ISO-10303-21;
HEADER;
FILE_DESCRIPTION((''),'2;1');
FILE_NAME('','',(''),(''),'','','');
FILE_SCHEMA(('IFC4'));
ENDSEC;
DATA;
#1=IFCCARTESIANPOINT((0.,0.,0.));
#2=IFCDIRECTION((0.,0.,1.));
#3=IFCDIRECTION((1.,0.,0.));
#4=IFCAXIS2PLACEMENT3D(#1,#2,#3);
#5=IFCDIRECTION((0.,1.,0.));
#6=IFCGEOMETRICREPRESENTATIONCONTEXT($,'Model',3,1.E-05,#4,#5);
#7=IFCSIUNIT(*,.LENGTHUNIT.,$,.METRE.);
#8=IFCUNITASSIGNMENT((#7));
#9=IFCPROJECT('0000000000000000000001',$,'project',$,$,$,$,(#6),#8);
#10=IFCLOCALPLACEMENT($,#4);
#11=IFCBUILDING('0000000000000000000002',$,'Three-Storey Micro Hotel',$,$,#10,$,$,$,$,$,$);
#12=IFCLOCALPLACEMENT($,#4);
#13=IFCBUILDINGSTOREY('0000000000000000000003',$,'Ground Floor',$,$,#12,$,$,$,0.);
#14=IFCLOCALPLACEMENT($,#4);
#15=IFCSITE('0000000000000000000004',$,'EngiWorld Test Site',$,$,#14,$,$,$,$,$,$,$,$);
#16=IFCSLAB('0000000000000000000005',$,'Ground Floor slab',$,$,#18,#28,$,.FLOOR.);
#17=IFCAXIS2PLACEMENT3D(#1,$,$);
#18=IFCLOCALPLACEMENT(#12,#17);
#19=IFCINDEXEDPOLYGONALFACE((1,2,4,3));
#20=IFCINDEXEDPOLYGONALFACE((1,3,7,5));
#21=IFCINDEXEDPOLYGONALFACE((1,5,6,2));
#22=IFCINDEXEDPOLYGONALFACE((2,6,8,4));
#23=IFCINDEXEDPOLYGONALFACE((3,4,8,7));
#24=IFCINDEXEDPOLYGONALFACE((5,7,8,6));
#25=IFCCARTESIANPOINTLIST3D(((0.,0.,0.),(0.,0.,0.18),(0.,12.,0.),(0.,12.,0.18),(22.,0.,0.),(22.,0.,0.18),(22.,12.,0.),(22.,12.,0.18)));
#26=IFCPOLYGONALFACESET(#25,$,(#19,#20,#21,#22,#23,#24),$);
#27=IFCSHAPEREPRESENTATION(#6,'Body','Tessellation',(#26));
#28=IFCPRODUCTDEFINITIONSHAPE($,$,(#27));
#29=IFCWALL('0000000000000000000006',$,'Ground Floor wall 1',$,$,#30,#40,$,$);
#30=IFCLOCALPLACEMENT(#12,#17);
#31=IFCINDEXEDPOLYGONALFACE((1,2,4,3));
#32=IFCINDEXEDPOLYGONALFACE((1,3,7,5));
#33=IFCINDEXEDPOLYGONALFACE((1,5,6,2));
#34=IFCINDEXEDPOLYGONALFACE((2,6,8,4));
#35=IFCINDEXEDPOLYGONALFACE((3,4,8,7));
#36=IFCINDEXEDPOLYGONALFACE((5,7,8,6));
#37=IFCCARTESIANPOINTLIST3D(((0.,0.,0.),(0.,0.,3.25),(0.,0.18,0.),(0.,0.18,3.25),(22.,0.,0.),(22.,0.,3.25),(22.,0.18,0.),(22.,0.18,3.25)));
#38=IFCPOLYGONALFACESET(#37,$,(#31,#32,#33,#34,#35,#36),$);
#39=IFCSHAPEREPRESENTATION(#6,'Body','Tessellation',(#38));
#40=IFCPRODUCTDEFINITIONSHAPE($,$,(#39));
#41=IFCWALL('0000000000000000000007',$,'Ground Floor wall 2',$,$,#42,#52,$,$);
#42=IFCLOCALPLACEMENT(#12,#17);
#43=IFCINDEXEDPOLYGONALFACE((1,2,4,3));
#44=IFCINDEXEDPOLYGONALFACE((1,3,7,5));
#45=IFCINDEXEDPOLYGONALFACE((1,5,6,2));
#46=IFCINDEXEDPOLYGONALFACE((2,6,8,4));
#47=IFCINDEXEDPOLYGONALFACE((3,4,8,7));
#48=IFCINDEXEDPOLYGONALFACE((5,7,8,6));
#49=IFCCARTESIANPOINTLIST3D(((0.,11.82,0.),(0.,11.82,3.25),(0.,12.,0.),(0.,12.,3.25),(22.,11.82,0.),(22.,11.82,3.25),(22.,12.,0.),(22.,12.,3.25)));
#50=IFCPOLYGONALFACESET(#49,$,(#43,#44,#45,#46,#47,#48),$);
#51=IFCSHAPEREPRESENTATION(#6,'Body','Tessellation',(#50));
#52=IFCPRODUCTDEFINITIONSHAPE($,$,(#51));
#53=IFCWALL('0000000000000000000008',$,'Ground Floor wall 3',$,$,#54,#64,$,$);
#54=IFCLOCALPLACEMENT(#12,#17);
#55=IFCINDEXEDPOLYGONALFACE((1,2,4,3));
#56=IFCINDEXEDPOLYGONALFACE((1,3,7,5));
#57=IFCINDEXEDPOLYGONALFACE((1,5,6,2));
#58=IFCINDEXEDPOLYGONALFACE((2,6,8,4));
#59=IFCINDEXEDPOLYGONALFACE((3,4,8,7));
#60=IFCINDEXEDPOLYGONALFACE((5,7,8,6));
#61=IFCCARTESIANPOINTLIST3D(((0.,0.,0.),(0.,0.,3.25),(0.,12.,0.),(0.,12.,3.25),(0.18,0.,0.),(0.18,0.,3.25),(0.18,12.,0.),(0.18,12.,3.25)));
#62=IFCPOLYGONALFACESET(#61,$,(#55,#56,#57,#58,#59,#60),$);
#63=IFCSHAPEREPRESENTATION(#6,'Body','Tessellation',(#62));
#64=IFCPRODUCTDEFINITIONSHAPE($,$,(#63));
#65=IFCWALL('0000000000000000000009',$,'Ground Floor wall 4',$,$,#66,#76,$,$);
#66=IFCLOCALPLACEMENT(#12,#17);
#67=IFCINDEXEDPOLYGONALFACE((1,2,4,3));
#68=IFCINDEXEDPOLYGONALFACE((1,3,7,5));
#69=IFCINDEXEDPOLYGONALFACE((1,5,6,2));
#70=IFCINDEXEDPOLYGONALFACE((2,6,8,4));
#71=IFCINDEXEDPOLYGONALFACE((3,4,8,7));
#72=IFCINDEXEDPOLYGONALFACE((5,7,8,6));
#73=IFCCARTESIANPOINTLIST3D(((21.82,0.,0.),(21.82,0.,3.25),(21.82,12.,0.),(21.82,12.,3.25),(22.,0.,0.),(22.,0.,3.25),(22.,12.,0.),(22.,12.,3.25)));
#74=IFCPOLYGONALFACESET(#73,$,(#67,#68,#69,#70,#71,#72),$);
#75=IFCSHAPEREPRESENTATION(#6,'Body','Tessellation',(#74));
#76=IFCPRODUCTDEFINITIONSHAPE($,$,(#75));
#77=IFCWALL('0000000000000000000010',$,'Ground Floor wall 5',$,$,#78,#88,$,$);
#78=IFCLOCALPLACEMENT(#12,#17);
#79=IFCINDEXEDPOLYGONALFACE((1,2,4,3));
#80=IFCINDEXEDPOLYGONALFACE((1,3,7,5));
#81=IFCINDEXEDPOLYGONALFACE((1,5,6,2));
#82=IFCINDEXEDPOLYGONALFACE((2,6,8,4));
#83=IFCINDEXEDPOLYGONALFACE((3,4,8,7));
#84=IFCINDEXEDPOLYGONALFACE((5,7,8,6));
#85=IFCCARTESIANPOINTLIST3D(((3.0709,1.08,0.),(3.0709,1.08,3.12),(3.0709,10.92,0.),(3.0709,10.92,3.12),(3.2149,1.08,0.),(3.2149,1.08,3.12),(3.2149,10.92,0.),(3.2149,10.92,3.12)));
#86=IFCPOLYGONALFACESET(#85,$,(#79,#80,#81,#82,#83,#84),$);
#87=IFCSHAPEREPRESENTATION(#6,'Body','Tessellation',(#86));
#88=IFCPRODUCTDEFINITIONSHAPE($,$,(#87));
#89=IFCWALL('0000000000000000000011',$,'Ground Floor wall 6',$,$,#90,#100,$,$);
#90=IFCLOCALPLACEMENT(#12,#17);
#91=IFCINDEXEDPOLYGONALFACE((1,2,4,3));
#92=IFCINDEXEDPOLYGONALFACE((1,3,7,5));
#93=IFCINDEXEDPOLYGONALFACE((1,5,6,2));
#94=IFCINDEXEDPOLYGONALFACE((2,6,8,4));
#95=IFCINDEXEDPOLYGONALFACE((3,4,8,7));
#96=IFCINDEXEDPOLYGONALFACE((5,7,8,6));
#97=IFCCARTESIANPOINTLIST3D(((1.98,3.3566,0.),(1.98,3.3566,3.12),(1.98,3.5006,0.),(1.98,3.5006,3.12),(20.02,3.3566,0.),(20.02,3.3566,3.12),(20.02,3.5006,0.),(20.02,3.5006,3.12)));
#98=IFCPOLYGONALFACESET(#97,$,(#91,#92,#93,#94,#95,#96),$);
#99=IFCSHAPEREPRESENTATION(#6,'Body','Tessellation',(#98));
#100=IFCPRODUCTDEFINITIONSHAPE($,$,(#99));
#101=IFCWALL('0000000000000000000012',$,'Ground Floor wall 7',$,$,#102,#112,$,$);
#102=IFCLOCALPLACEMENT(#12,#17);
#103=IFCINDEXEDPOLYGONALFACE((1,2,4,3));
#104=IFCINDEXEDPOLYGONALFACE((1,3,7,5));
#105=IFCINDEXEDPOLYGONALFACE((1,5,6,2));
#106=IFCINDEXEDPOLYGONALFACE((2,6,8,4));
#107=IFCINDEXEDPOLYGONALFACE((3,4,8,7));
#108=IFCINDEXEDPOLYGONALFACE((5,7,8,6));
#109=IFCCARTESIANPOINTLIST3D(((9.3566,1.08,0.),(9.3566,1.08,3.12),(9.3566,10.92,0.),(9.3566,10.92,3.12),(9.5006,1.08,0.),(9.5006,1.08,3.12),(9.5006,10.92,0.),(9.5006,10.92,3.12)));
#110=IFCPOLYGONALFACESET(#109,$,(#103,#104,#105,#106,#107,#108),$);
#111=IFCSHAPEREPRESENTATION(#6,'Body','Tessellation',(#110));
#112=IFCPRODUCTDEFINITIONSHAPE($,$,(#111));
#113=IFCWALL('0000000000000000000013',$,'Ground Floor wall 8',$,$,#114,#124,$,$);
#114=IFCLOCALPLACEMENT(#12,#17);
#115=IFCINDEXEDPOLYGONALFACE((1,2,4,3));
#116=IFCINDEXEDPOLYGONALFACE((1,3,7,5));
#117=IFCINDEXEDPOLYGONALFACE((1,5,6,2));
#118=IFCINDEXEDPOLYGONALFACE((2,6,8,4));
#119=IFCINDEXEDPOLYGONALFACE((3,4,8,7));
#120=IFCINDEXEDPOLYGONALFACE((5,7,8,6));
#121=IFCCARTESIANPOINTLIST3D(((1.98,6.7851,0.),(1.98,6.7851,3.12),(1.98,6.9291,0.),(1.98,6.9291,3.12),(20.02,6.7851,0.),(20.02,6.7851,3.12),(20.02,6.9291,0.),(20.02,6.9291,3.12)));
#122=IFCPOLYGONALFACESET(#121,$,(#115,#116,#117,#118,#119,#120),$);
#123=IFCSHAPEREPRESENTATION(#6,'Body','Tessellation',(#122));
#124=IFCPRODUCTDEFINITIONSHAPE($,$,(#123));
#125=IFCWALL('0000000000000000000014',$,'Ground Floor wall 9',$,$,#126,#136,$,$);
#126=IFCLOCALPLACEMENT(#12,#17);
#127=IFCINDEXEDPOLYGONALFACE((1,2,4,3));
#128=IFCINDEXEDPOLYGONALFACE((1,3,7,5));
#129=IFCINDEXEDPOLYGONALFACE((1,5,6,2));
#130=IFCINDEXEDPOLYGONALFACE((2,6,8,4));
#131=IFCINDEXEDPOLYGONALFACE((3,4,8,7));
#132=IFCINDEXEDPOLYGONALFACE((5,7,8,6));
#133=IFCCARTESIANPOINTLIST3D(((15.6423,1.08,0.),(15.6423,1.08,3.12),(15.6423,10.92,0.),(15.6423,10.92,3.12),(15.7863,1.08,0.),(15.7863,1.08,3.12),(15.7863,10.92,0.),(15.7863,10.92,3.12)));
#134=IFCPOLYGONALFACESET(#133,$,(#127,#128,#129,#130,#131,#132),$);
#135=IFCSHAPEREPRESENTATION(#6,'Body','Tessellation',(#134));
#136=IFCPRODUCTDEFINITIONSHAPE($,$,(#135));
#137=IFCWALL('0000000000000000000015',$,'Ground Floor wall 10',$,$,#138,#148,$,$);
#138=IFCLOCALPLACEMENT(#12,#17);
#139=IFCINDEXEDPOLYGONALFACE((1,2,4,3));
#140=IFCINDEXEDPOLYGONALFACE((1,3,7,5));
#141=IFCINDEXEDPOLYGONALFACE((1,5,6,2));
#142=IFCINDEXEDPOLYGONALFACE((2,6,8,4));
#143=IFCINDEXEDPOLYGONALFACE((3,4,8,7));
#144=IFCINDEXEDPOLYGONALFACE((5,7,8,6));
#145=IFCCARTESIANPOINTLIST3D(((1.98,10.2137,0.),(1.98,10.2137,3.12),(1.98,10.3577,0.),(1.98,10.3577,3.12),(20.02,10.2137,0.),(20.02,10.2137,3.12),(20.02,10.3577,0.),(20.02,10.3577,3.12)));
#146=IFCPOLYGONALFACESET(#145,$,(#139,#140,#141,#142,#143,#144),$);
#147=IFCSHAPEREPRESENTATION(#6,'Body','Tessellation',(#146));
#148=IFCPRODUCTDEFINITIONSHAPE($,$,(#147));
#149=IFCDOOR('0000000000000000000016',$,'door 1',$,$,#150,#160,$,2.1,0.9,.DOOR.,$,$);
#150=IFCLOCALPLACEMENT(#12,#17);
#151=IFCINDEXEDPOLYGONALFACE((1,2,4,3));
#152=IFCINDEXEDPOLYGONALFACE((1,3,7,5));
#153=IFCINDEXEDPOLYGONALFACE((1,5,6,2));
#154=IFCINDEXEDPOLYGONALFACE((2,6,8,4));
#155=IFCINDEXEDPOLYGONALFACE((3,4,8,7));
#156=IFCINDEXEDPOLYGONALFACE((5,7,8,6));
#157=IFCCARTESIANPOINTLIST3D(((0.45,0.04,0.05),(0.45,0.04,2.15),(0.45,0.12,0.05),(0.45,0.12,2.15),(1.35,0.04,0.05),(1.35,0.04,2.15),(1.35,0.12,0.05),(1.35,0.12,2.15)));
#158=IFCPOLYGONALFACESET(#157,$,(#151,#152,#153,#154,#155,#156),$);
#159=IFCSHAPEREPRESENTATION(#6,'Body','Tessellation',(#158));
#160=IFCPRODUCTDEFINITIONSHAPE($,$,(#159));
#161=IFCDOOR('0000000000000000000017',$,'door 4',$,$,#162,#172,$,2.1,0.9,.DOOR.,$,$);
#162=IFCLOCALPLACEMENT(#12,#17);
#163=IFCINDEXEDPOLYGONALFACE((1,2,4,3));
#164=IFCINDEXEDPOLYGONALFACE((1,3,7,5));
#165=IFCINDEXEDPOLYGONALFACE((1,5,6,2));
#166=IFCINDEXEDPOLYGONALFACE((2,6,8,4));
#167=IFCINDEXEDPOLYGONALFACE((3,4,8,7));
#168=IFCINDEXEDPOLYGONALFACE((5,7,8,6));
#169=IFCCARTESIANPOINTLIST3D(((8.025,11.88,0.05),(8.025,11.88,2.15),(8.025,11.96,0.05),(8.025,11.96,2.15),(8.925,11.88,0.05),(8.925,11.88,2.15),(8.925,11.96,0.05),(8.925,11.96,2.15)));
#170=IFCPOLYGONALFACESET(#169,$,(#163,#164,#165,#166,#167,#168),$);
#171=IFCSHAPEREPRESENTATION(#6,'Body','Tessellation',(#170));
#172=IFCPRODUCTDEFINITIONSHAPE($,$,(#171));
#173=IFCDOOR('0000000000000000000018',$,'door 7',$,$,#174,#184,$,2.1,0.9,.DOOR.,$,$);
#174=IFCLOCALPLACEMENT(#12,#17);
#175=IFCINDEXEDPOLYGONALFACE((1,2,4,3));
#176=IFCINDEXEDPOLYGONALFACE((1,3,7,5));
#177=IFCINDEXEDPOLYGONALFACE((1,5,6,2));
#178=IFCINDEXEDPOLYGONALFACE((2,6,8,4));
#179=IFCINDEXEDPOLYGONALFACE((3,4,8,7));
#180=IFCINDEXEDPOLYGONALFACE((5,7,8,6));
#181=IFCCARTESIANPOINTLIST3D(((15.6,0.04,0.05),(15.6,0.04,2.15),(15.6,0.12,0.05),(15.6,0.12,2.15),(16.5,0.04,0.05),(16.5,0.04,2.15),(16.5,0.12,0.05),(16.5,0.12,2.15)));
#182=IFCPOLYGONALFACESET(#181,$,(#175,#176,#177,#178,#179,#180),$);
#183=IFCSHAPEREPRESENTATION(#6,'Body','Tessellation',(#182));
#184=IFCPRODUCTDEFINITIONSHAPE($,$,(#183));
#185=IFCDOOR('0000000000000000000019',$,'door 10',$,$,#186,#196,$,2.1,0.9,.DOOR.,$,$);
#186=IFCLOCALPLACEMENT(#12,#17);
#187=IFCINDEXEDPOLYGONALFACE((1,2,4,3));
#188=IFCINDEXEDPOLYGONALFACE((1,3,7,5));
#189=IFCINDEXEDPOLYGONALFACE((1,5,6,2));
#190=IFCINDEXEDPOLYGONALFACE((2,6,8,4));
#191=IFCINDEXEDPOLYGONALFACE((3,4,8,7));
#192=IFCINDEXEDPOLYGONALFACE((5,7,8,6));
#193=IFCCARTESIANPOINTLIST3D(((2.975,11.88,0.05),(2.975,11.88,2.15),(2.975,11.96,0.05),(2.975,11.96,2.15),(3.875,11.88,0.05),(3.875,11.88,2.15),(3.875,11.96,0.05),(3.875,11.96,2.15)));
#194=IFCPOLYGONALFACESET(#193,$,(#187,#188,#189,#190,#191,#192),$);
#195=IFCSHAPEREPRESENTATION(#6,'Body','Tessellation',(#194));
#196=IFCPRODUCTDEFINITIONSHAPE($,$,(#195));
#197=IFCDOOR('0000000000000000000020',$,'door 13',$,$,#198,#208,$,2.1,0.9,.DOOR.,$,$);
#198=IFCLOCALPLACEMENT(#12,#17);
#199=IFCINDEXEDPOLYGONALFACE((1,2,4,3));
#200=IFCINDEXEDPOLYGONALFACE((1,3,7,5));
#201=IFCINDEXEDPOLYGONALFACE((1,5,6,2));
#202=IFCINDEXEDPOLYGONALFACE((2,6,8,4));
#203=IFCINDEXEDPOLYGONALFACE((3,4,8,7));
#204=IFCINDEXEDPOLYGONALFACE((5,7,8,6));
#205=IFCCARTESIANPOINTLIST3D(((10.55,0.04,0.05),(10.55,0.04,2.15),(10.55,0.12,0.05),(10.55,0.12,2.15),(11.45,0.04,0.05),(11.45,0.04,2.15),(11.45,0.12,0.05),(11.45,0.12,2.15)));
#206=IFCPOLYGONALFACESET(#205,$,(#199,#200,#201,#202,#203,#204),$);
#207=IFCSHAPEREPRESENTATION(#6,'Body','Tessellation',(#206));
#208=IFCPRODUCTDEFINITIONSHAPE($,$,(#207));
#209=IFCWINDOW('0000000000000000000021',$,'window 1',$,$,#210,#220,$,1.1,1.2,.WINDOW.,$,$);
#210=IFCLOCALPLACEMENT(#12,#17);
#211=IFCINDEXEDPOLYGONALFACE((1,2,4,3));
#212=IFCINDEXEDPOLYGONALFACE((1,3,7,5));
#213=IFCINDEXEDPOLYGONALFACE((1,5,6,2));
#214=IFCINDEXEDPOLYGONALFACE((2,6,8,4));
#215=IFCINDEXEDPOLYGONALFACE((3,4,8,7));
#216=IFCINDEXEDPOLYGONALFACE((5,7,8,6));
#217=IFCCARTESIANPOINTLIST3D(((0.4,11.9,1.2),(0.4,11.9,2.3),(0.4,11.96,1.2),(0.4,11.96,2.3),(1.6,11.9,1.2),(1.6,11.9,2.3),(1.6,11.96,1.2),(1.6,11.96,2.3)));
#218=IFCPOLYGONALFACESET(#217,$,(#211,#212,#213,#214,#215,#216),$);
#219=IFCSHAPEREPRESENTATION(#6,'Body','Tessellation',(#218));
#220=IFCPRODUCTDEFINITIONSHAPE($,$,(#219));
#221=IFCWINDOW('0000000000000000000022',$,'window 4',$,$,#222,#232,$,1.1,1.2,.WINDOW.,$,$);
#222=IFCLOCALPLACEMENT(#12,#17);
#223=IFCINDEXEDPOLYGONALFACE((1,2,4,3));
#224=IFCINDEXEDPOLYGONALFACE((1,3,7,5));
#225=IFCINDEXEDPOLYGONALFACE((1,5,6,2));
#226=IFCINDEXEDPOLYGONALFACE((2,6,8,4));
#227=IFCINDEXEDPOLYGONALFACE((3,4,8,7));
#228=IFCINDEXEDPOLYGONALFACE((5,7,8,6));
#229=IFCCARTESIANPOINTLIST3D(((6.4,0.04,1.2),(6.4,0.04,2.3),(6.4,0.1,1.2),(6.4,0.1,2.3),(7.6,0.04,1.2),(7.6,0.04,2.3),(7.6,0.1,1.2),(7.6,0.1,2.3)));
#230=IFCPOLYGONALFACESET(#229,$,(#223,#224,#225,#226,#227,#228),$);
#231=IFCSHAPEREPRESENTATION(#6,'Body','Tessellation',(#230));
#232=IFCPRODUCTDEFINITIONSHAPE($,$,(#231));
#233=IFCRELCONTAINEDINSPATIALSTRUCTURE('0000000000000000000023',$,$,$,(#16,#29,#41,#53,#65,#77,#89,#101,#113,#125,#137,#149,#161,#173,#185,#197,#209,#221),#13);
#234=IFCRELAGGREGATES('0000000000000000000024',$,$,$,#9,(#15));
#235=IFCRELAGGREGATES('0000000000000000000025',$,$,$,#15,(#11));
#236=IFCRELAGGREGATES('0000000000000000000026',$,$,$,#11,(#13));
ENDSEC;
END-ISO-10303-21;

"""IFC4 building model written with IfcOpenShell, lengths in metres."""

from ifc_helpers import new_model, si_unit, direction, frame, origin_with_axes, origin_2d_with_axis, place, context, project, spatial, rectangle, extrude, element, save


model = new_model("IFC4")

# Units and contexts
model_context = context("Model", 3, precision=1e-05, world=origin_with_axes(), true_north=direction((0.0, 1.0, 0.0)))
ifc_project = project(units=[si_unit("LENGTHUNIT", "METRE")], contexts=[model_context])

# Site, building, storey
site_placement = place(None, origin_with_axes())
site = spatial("IfcSite", under=ifc_project, at=site_placement, Name="EngiWorld Test Site")
building_placement = place(None, origin_with_axes())
building = spatial("IfcBuilding", under=site, at=building_placement, Name="Three-Storey Micro Hotel")
storey_placement = place(None, origin_with_axes())
storey = spatial("IfcBuildingStorey", under=building, at=storey_placement, Name="Ground Floor", Elevation=0.0)

# Slab
slab_placement = place(None, frame((11.0, 6.0, 0.0), z_axis=(0.0, 0.0, 1.0), x_axis=(1.0, 0.0, 0.0)))
element("IfcSlab", 1, at=slab_placement, inside=storey, Name="Ground Floor slab", PredefinedType="FLOOR", context=model_context, shape_type="SweptSolid", body=[
    extrude(rectangle(XDim=22.0, YDim=12.0, at=origin_2d_with_axis()), origin_with_axes(), (0.0, 0.0, 1.0), 0.18),
])

# Walls
for number, where, z_axis, x_axis, name in (
    (2, (11.0, 0.09, 0.0), (0.0, 0.0, 1.0), (1.0, 0.0, 0.0), "Ground Floor wall 1"),
    (3, (11.0, 11.91, 0.0), (0.0, 0.0, 1.0), (1.0, 0.0, 0.0), "Ground Floor wall 2"),
):
    element("IfcWall", number, at=place(None, frame(where, z_axis=z_axis, x_axis=x_axis)), inside=storey, Name=name, context=model_context, shape_type="SweptSolid", body=[
        extrude(rectangle(XDim=22.0, YDim=0.18, at=origin_2d_with_axis()), origin_with_axes(), (0.0, 0.0, 1.0), 3.25),
    ])
for number, where, z_axis, x_axis, name in (
    (4, (0.09, 6.0, 0.0), (0.0, 0.0, 1.0), (1.0, 0.0, 0.0), "Ground Floor wall 3"),
    (5, (21.91, 6.0, 0.0), (0.0, 0.0, 1.0), (1.0, 0.0, 0.0), "Ground Floor wall 4"),
):
    element("IfcWall", number, at=place(None, frame(where, z_axis=z_axis, x_axis=x_axis)), inside=storey, Name=name, context=model_context, shape_type="SweptSolid", body=[
        extrude(rectangle(XDim=0.18, YDim=12.0, at=origin_2d_with_axis()), origin_with_axes(), (0.0, 0.0, 1.0), 3.25),
    ])
wall_1_placement = place(None, frame((3.1429, 6.0, 0.0), z_axis=(0.0, 0.0, 1.0), x_axis=(1.0, 0.0, 0.0)))
element("IfcWall", 6, at=wall_1_placement, inside=storey, Name="Ground Floor wall 5", context=model_context, shape_type="SweptSolid", body=[
    extrude(rectangle(XDim=0.144, YDim=9.84, at=origin_2d_with_axis()), origin_with_axes(), (0.0, 0.0, 1.0), 3.12),
])
wall_2_placement = place(None, frame((11.0, 3.4286, 0.0), z_axis=(0.0, 0.0, 1.0), x_axis=(1.0, 0.0, 0.0)))
element("IfcWall", 7, at=wall_2_placement, inside=storey, Name="Ground Floor wall 6", context=model_context, shape_type="SweptSolid", body=[
    extrude(rectangle(XDim=18.04, YDim=0.144, at=origin_2d_with_axis()), origin_with_axes(), (0.0, 0.0, 1.0), 3.12),
])
wall_3_placement = place(None, frame((9.4286, 6.0, 0.0), z_axis=(0.0, 0.0, 1.0), x_axis=(1.0, 0.0, 0.0)))
element("IfcWall", 8, at=wall_3_placement, inside=storey, Name="Ground Floor wall 7", context=model_context, shape_type="SweptSolid", body=[
    extrude(rectangle(XDim=0.144, YDim=9.84, at=origin_2d_with_axis()), origin_with_axes(), (0.0, 0.0, 1.0), 3.12),
])
wall_4_placement = place(None, frame((11.0, 6.8571, 0.0), z_axis=(0.0, 0.0, 1.0), x_axis=(1.0, 0.0, 0.0)))
element("IfcWall", 9, at=wall_4_placement, inside=storey, Name="Ground Floor wall 8", context=model_context, shape_type="SweptSolid", body=[
    extrude(rectangle(XDim=18.04, YDim=0.144, at=origin_2d_with_axis()), origin_with_axes(), (0.0, 0.0, 1.0), 3.12),
])
wall_5_placement = place(None, frame((15.7143, 6.0, 0.0), z_axis=(0.0, 0.0, 1.0), x_axis=(1.0, 0.0, 0.0)))
element("IfcWall", 10, at=wall_5_placement, inside=storey, Name="Ground Floor wall 9", context=model_context, shape_type="SweptSolid", body=[
    extrude(rectangle(XDim=0.144, YDim=9.84, at=origin_2d_with_axis()), origin_with_axes(), (0.0, 0.0, 1.0), 3.12),
])
wall_6_placement = place(None, frame((11.0, 10.2857, 0.0), z_axis=(0.0, 0.0, 1.0), x_axis=(1.0, 0.0, 0.0)))
element("IfcWall", 11, at=wall_6_placement, inside=storey, Name="Ground Floor wall 10", context=model_context, shape_type="SweptSolid", body=[
    extrude(rectangle(XDim=18.04, YDim=0.144, at=origin_2d_with_axis()), origin_with_axes(), (0.0, 0.0, 1.0), 3.12),
])

# Doors
for number, where, z_axis, x_axis, name in (
    (12, (0.9, 0.08, 0.05), (0.0, 0.0, 1.0), (1.0, 0.0, 0.0), "door 1"),
    (13, (8.475, 11.92, 0.05), (0.0, 0.0, 1.0), (1.0, 0.0, 0.0), "door 4"),
    (14, (16.05, 0.08, 0.05), (0.0, 0.0, 1.0), (1.0, 0.0, 0.0), "door 7"),
    (15, (3.425, 11.92, 0.05), (0.0, 0.0, 1.0), (1.0, 0.0, 0.0), "door 10"),
    (16, (11.0, 0.08, 0.05), (0.0, 0.0, 1.0), (1.0, 0.0, 0.0), "door 13"),
):
    element("IfcDoor", number, at=place(None, frame(where, z_axis=z_axis, x_axis=x_axis)), inside=storey, Name=name, OverallHeight=2.1, OverallWidth=0.9, PredefinedType="DOOR", context=model_context, shape_type="SweptSolid", body=[
        extrude(rectangle(XDim=0.9, YDim=0.08, at=origin_2d_with_axis()), origin_with_axes(), (0.0, 0.0, 1.0), 2.1),
    ])

# Windows
for number, where, z_axis, x_axis, name in (
    (17, (1.0, 11.93, 1.2), (0.0, 0.0, 1.0), (1.0, 0.0, 0.0), "window 1"),
    (18, (7.0, 0.07, 1.2), (0.0, 0.0, 1.0), (1.0, 0.0, 0.0), "window 4"),
):
    element("IfcWindow", number, at=place(None, frame(where, z_axis=z_axis, x_axis=x_axis)), inside=storey, Name=name, OverallHeight=1.1, OverallWidth=1.2, PredefinedType="WINDOW", context=model_context, shape_type="SweptSolid", body=[
        extrude(rectangle(XDim=1.2, YDim=0.06, at=origin_2d_with_axis()), origin_with_axes(), (0.0, 0.0, 1.0), 1.1),
    ])

save(model, "model.ifc")
